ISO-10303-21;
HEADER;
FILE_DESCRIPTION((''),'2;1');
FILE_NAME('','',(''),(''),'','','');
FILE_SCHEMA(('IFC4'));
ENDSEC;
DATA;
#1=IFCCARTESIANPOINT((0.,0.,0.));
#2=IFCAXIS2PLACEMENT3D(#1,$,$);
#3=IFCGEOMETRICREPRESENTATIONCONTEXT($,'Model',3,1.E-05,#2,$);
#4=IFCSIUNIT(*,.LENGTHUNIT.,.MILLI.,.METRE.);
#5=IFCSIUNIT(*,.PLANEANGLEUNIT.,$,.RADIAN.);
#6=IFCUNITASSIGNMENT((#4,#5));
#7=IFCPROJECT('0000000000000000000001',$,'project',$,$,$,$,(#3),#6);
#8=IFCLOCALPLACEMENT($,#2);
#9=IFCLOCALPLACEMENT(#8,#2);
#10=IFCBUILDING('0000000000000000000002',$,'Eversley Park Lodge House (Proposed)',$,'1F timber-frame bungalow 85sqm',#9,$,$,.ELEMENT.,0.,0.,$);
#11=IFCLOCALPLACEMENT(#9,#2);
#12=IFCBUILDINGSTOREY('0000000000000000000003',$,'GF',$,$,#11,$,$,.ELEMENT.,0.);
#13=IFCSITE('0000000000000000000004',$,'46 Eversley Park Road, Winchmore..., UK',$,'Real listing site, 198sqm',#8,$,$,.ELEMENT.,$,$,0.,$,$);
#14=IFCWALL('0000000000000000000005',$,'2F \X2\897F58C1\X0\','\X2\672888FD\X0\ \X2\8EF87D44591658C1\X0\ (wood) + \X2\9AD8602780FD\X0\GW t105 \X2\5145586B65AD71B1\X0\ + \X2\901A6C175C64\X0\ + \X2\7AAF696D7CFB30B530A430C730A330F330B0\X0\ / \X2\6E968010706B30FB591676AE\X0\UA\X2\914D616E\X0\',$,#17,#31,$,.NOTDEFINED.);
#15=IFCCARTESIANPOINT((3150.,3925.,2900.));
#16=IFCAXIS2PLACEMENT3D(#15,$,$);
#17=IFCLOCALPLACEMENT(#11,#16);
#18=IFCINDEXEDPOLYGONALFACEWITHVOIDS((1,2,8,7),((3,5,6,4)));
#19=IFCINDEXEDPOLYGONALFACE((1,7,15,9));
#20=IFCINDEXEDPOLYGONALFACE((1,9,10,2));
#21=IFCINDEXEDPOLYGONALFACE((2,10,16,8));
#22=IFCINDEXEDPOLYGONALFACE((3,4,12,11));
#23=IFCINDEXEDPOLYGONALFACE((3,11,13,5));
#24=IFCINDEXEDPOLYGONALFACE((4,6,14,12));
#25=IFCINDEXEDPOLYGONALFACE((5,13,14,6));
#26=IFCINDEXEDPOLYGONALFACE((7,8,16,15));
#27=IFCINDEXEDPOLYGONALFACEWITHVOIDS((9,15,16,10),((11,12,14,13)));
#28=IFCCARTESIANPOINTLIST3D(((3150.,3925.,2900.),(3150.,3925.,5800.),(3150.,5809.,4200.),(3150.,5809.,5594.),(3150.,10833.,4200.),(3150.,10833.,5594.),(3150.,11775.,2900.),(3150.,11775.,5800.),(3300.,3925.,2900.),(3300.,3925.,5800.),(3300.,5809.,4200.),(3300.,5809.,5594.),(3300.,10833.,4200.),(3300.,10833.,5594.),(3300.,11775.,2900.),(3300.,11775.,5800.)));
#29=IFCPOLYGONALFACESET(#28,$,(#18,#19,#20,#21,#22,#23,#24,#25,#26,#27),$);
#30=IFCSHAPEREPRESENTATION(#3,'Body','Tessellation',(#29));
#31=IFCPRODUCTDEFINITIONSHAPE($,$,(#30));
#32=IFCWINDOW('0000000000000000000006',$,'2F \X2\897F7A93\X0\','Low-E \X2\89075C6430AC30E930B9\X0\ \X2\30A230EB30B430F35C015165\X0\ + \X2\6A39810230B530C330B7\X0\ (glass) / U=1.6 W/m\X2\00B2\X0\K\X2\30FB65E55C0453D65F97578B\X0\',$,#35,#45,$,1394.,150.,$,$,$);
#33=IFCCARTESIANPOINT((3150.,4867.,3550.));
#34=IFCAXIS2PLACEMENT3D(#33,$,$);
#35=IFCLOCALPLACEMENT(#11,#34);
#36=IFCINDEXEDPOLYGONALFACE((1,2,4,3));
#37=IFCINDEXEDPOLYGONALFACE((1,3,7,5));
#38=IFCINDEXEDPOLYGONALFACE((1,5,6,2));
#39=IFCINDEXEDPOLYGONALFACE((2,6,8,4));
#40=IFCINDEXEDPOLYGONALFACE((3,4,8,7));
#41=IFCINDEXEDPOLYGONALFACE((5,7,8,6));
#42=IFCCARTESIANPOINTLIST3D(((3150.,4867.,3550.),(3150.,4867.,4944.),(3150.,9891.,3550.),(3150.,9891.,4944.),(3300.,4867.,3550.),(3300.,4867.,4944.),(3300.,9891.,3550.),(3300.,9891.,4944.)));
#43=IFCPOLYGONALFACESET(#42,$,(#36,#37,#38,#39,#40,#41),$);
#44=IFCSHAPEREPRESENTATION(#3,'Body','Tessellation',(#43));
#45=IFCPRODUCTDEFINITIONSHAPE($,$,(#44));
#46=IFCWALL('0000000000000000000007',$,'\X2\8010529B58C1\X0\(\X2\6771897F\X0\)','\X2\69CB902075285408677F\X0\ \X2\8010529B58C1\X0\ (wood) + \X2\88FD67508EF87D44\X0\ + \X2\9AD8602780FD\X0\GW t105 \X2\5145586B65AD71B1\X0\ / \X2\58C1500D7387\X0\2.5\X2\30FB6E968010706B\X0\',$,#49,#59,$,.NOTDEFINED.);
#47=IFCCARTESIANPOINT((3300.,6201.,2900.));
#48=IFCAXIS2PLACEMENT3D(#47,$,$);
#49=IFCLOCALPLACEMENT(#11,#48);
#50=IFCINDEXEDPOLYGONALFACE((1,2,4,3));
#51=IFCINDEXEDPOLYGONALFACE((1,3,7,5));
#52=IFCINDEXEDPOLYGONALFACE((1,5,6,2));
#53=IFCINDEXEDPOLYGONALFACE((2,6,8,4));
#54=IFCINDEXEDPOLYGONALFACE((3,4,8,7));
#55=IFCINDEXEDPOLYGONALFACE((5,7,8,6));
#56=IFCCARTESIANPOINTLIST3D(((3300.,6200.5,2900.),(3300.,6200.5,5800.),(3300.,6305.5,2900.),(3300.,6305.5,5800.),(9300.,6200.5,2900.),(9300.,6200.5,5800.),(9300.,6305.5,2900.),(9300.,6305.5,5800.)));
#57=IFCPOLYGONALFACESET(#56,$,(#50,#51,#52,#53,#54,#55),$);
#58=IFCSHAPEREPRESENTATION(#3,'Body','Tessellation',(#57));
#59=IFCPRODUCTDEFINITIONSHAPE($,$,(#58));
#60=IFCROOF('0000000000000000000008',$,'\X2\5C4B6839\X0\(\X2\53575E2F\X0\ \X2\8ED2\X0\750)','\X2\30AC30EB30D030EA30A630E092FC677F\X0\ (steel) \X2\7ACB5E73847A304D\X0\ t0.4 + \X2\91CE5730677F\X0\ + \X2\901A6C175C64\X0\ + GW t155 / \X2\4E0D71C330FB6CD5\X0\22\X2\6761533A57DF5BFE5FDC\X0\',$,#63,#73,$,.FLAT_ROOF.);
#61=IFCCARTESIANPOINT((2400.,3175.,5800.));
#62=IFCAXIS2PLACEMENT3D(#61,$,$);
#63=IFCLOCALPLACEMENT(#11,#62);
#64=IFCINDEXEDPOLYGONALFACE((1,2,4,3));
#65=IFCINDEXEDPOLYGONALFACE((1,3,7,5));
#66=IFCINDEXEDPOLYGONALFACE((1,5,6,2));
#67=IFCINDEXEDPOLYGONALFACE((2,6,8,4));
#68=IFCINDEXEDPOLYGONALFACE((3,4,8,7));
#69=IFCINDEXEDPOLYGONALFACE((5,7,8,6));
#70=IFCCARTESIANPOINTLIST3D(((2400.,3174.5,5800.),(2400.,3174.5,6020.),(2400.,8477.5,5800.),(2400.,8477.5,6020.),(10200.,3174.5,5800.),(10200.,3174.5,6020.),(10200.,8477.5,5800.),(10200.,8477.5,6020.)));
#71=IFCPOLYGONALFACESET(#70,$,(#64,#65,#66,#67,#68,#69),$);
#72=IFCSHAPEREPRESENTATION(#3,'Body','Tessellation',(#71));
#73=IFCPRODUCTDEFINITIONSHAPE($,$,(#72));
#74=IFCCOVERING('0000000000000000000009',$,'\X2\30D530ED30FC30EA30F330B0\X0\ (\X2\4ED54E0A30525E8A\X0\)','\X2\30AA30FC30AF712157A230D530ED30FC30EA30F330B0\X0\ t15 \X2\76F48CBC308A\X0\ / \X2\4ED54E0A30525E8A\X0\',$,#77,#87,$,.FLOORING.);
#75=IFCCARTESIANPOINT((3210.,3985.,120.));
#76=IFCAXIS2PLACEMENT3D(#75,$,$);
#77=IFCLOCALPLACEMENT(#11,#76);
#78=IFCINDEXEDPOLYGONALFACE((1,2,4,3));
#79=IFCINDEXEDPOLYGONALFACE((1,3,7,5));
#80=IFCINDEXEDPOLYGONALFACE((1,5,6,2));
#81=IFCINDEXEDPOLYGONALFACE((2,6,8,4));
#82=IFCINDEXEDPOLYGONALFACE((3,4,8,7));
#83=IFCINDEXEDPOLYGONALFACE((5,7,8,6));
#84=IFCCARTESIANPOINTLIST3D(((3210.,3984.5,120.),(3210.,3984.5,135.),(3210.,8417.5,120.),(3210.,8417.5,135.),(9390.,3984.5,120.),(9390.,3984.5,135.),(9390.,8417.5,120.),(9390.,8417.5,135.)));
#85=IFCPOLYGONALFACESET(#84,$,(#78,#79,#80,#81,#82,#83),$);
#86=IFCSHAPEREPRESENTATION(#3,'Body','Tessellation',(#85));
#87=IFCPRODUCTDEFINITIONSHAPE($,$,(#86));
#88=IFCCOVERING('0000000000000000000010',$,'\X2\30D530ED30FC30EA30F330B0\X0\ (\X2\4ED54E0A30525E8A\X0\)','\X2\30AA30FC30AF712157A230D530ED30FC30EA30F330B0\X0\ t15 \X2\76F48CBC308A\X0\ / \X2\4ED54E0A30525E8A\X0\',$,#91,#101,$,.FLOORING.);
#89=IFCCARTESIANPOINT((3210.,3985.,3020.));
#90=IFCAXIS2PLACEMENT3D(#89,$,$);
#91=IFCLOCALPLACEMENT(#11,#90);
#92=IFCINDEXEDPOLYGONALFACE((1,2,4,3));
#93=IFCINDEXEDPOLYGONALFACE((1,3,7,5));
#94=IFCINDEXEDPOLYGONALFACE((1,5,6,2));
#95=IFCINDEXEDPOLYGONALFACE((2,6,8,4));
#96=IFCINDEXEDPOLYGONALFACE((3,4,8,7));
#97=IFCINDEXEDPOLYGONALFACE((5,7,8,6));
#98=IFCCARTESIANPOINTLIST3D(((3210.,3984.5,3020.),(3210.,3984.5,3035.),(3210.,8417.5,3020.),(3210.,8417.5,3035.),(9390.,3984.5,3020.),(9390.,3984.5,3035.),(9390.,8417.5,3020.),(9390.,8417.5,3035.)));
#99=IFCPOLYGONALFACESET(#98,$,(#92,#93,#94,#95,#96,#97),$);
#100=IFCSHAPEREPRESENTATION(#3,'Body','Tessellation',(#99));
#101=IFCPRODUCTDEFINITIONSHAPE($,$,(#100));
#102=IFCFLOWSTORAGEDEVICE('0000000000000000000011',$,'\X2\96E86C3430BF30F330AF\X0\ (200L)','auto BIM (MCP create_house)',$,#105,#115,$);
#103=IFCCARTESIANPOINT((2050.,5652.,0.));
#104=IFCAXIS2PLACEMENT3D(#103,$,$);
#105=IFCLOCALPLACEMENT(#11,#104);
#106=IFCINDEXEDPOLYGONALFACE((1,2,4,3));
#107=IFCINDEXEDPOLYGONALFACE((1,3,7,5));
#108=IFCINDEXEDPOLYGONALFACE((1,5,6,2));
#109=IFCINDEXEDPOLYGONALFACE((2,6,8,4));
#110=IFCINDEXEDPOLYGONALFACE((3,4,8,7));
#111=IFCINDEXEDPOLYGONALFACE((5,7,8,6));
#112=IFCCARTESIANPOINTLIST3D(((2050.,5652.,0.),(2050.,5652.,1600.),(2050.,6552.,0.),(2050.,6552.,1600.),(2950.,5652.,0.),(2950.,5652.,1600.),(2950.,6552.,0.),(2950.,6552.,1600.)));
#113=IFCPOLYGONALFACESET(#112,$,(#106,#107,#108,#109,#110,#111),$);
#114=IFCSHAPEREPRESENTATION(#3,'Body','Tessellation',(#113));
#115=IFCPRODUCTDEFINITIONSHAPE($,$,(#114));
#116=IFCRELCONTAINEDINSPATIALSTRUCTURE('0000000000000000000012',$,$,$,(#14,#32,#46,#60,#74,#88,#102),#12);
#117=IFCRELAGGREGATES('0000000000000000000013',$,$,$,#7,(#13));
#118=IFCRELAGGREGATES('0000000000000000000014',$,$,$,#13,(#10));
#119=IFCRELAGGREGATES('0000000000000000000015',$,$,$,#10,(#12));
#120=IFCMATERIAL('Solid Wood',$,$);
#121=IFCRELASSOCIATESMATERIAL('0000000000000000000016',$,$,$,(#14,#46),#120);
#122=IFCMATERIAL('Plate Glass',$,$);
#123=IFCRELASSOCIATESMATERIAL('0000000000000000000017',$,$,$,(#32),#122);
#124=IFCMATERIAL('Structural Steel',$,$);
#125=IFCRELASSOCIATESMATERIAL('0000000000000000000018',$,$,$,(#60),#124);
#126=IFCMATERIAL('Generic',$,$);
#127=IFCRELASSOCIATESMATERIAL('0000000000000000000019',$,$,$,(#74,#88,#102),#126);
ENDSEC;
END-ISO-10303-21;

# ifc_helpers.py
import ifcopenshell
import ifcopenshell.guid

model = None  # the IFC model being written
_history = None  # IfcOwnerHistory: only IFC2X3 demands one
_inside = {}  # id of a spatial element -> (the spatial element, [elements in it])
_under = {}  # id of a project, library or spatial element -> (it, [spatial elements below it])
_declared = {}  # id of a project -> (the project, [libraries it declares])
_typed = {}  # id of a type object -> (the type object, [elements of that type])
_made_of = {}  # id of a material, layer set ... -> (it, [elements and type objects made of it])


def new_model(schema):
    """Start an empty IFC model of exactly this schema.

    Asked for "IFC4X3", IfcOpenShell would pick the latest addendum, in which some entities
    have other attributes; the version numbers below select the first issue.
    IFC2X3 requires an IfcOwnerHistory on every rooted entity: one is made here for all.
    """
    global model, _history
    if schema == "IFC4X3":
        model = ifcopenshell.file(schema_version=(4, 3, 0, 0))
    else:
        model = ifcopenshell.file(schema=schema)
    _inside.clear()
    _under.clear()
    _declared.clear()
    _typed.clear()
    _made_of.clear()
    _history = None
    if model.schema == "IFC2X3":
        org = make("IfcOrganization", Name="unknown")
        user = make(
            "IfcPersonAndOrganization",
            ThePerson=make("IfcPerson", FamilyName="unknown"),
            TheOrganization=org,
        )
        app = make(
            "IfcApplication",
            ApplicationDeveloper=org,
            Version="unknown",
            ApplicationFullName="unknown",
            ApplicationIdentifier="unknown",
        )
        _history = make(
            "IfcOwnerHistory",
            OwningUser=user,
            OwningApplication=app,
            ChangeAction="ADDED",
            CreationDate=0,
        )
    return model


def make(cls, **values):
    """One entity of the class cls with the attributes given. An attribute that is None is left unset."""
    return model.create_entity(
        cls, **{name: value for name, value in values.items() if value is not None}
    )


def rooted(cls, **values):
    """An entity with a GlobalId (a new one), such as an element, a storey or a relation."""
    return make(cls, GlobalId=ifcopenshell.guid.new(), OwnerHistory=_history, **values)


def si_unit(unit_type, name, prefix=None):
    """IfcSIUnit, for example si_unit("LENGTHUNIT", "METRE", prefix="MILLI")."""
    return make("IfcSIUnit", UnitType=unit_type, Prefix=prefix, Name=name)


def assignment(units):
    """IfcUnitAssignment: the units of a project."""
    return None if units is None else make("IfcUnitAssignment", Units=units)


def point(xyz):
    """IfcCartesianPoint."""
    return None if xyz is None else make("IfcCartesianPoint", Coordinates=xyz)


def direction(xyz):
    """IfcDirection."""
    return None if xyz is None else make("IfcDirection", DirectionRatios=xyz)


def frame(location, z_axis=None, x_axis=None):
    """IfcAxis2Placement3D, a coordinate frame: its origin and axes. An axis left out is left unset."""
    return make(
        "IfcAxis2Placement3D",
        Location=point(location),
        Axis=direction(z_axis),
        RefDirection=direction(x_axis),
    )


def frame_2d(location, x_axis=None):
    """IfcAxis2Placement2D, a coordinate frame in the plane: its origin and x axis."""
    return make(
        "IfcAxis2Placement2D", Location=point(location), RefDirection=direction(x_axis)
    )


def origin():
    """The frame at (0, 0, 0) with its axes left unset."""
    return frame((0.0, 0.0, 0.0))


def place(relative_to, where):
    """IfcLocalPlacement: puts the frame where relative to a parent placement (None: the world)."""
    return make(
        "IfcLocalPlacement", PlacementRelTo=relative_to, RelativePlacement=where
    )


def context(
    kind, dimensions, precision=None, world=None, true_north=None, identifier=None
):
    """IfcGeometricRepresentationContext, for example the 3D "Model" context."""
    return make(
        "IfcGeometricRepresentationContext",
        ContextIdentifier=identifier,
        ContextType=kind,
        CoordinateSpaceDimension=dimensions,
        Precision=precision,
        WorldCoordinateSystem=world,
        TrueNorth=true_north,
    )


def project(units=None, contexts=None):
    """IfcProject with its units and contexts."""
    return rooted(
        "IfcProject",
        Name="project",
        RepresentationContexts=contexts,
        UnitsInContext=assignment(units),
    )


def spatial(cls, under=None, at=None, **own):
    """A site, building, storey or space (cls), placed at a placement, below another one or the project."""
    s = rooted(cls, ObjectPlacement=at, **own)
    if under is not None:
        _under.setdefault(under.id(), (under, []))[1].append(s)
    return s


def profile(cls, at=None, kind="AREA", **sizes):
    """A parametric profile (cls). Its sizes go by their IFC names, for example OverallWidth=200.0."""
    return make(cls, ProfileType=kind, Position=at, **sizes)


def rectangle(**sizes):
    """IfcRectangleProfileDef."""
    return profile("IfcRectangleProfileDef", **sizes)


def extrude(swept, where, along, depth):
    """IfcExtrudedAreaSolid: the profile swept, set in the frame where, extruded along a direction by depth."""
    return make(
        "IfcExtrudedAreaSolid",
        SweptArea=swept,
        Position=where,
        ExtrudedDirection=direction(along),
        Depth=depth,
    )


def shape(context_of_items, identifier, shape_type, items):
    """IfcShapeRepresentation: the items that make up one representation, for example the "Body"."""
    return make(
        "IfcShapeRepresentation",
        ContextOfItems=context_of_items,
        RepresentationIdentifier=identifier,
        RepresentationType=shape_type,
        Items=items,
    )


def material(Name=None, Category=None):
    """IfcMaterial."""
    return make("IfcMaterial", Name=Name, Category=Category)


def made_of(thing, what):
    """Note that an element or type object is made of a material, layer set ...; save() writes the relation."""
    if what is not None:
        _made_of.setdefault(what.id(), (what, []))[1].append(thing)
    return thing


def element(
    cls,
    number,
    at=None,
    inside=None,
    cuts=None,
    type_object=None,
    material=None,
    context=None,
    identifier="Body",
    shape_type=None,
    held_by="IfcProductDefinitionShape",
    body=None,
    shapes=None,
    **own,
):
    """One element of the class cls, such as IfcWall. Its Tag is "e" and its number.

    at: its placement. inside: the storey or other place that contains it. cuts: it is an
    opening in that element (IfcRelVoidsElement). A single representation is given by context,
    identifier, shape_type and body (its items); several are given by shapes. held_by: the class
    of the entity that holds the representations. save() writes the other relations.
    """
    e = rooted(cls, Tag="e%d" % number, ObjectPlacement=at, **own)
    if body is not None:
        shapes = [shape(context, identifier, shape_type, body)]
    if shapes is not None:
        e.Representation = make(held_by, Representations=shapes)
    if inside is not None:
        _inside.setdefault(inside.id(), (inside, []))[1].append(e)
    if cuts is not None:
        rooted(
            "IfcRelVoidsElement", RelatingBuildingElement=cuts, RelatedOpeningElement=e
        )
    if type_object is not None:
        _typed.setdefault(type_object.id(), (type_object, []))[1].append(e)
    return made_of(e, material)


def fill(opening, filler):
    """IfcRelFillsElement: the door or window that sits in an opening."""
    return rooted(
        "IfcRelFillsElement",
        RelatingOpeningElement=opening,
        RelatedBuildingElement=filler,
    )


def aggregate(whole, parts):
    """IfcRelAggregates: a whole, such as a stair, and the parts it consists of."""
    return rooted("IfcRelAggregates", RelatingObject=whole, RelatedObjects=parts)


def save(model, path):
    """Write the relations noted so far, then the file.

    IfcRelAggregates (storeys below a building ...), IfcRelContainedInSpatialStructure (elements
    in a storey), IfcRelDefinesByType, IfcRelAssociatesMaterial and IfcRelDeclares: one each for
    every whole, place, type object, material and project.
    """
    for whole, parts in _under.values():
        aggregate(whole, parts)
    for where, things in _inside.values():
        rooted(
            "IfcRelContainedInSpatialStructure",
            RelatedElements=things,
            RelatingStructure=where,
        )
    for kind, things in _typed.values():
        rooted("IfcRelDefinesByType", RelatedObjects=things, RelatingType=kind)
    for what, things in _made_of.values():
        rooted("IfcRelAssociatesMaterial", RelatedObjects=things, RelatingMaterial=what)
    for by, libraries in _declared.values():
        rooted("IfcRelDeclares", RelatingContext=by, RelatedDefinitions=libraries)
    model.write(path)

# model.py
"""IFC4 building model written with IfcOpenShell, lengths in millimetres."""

from ifc_helpers import new_model, si_unit, frame, frame_2d, origin, place, context, project, spatial, rectangle, extrude, material, element, fill, save


model = new_model("IFC4")

# Units and contexts
model_context = context("Model", 3, precision=1e-05, world=origin())
ifc_project = project(units=[si_unit("LENGTHUNIT", "METRE", prefix="MILLI"), si_unit("PLANEANGLEUNIT", "RADIAN")], contexts=[model_context])

# Site, building, storey
site_placement = place(None, origin())
site = spatial("IfcSite", under=ifc_project, at=site_placement, Name="46 Eversley Park Road, Winchmore..., UK", ObjectType="Real listing site, 198sqm", CompositionType="ELEMENT", RefElevation=0.0)
building_placement = place(site_placement, origin())
building = spatial("IfcBuilding", under=site, at=building_placement, Name="Eversley Park Lodge House (Proposed)", ObjectType="1F timber-frame bungalow 85sqm", CompositionType="ELEMENT", ElevationOfRefHeight=0.0, ElevationOfTerrain=0.0)
storey_placement = place(building_placement, origin())
storey = spatial("IfcBuildingStorey", under=building, at=storey_placement, Name="GF", CompositionType="ELEMENT", Elevation=0.0)

# Shared definitions
ifc_material_1 = material(Name="Solid Wood")
ifc_material_2 = material(Name="Generic")

# Shared definitions
ifc_material_3 = material(Name="Plate Glass")

# Wall, opening, window
wall_1_placement = place(storey_placement, frame((3150.0, 3925.0, 2900.0)))
wall_1 = element("IfcWall", 1, at=wall_1_placement, inside=storey, material=ifc_material_1, Name="2F 西壁", Description="木製 軸組外壁 (wood) + 高性能GW t105 充填断熱 + 通気層 + 窯業系サイディング / 準耐火・外皮UA配慮", PredefinedType="NOTDEFINED", context=model_context, shape_type="SweptSolid", body=[
    extrude(rectangle(XDim=150.0, YDim=7850.0, at=frame_2d((75.0, 3925.0))), frame((3150.0, 3925.0, 2900.0)), (0.0, 0.0, 1.0), 2900.0),
])
opening_1_placement = place(storey_placement, frame((3150.0, 4867.0, 3550.0)))
opening_1 = element("IfcOpeningElement", 2, at=opening_1_placement, cuts=wall_1, PredefinedType="NOTDEFINED", context=model_context, shape_type="SweptSolid", body=[
    extrude(rectangle(XDim=150.0, YDim=5024.0, at=frame_2d((75.0, 2512.0))), frame((3150.0, 4867.0, 3550.0)), (0.0, 0.0, 1.0), 1394.0),
])
window_1_placement = place(storey_placement, frame((3150.0, 4867.0, 3550.0)))
window_1 = element("IfcWindow", 3, at=window_1_placement, inside=storey, material=ifc_material_3, Name="2F 西窓", Description="Low-E 複層ガラス アルゴン封入 + 樹脂サッシ (glass) / U=1.6 W/m²K・日射取得型", OverallHeight=1394.0, OverallWidth=150.0, context=model_context, shape_type="SweptSolid", body=[
    extrude(rectangle(XDim=150.0, YDim=5024.0, at=frame_2d((75.0, 2512.0))), frame((3150.0, 4867.0, 3550.0)), (0.0, 0.0, 1.0), 1394.0),
])
fill(opening_1, window_1)

# Wall
wall_2_placement = place(storey_placement, frame((3300.0, 6201.0, 2900.0)))
element("IfcWall", 4, at=wall_2_placement, inside=storey, material=ifc_material_1, Name="耐力壁(東西)", Description="構造用合板 耐力壁 (wood) + 製材軸組 + 高性能GW t105 充填断熱 / 壁倍率2.5・準耐火", PredefinedType="NOTDEFINED", context=model_context, shape_type="SweptSolid", body=[
    extrude(rectangle(XDim=6000.0, YDim=105.0, at=frame_2d((3000.0, 52.0))), frame((3300.0, 6201.0, 2900.0)), (0.0, 0.0, 1.0), 2900.0),
])

# Roof
ifc_material_4 = material(Name="Structural Steel")
for number, where, name in (
    (5, (2400.0, 3175.0, 5800.0), "屋根(南帯 軒750)"),
):
    element("IfcRoof", number, at=place(storey_placement, frame(where)), inside=storey, material=ifc_material_4, Name=name, Description="ガルバリウム鋼板 (steel) 立平葺き t0.4 + 野地板 + 通気層 + GW t155 / 不燃・法22条区域対応", PredefinedType="FLAT_ROOF", context=model_context, shape_type="SweptSolid", body=[
        extrude(rectangle(XDim=7800.0, YDim=5303.0, at=frame_2d((3900.0, 2651.0))), frame((2400.0, 3175.0, 5800.0)), (0.0, 0.0, 1.0), 220.0),
    ])

# Coverings
covering_1_placement = place(storey_placement, frame((3210.0, 3985.0, 120.0)))
element("IfcCovering", 6, at=covering_1_placement, inside=storey, material=ifc_material_2, Name="フローリング (仕上げ床)", Description="オーク無垢フローリング t15 直貼り / 仕上げ床", PredefinedType="FLOORING", context=model_context, shape_type="SweptSolid", body=[
    extrude(rectangle(XDim=6180.0, YDim=4433.0, at=frame_2d((3090.0, 2216.0))), frame((3210.0, 3985.0, 120.0)), (0.0, 0.0, 1.0), 15.0),
])
covering_2_placement = place(storey_placement, frame((3210.0, 3985.0, 3020.0)))
element("IfcCovering", 7, at=covering_2_placement, inside=storey, material=ifc_material_2, Name="フローリング (仕上げ床)", Description="オーク無垢フローリング t15 直貼り / 仕上げ床", PredefinedType="FLOORING", context=model_context, shape_type="SweptSolid", body=[
    extrude(rectangle(XDim=6180.0, YDim=4433.0, at=frame_2d((3090.0, 2216.0))), frame((3210.0, 3985.0, 3020.0)), (0.0, 0.0, 1.0), 15.0),
])

# Flow storage device
flow_storage_device_placement = place(storey_placement, frame((2050.0, 5652.0, 0.0)))
element("IfcFlowStorageDevice", 8, at=flow_storage_device_placement, inside=storey, material=ifc_material_2, Name="雨水タンク (200L)", Description="auto BIM (MCP create_house)", context=model_context, shape_type="SweptSolid", body=[
    extrude(rectangle(XDim=900.0, YDim=900.0, at=frame_2d((450.0, 450.0))), frame((2050.0, 5652.0, 0.0)), (0.0, 0.0, 1.0), 1600.0),
])

save(model, "model.ifc")
